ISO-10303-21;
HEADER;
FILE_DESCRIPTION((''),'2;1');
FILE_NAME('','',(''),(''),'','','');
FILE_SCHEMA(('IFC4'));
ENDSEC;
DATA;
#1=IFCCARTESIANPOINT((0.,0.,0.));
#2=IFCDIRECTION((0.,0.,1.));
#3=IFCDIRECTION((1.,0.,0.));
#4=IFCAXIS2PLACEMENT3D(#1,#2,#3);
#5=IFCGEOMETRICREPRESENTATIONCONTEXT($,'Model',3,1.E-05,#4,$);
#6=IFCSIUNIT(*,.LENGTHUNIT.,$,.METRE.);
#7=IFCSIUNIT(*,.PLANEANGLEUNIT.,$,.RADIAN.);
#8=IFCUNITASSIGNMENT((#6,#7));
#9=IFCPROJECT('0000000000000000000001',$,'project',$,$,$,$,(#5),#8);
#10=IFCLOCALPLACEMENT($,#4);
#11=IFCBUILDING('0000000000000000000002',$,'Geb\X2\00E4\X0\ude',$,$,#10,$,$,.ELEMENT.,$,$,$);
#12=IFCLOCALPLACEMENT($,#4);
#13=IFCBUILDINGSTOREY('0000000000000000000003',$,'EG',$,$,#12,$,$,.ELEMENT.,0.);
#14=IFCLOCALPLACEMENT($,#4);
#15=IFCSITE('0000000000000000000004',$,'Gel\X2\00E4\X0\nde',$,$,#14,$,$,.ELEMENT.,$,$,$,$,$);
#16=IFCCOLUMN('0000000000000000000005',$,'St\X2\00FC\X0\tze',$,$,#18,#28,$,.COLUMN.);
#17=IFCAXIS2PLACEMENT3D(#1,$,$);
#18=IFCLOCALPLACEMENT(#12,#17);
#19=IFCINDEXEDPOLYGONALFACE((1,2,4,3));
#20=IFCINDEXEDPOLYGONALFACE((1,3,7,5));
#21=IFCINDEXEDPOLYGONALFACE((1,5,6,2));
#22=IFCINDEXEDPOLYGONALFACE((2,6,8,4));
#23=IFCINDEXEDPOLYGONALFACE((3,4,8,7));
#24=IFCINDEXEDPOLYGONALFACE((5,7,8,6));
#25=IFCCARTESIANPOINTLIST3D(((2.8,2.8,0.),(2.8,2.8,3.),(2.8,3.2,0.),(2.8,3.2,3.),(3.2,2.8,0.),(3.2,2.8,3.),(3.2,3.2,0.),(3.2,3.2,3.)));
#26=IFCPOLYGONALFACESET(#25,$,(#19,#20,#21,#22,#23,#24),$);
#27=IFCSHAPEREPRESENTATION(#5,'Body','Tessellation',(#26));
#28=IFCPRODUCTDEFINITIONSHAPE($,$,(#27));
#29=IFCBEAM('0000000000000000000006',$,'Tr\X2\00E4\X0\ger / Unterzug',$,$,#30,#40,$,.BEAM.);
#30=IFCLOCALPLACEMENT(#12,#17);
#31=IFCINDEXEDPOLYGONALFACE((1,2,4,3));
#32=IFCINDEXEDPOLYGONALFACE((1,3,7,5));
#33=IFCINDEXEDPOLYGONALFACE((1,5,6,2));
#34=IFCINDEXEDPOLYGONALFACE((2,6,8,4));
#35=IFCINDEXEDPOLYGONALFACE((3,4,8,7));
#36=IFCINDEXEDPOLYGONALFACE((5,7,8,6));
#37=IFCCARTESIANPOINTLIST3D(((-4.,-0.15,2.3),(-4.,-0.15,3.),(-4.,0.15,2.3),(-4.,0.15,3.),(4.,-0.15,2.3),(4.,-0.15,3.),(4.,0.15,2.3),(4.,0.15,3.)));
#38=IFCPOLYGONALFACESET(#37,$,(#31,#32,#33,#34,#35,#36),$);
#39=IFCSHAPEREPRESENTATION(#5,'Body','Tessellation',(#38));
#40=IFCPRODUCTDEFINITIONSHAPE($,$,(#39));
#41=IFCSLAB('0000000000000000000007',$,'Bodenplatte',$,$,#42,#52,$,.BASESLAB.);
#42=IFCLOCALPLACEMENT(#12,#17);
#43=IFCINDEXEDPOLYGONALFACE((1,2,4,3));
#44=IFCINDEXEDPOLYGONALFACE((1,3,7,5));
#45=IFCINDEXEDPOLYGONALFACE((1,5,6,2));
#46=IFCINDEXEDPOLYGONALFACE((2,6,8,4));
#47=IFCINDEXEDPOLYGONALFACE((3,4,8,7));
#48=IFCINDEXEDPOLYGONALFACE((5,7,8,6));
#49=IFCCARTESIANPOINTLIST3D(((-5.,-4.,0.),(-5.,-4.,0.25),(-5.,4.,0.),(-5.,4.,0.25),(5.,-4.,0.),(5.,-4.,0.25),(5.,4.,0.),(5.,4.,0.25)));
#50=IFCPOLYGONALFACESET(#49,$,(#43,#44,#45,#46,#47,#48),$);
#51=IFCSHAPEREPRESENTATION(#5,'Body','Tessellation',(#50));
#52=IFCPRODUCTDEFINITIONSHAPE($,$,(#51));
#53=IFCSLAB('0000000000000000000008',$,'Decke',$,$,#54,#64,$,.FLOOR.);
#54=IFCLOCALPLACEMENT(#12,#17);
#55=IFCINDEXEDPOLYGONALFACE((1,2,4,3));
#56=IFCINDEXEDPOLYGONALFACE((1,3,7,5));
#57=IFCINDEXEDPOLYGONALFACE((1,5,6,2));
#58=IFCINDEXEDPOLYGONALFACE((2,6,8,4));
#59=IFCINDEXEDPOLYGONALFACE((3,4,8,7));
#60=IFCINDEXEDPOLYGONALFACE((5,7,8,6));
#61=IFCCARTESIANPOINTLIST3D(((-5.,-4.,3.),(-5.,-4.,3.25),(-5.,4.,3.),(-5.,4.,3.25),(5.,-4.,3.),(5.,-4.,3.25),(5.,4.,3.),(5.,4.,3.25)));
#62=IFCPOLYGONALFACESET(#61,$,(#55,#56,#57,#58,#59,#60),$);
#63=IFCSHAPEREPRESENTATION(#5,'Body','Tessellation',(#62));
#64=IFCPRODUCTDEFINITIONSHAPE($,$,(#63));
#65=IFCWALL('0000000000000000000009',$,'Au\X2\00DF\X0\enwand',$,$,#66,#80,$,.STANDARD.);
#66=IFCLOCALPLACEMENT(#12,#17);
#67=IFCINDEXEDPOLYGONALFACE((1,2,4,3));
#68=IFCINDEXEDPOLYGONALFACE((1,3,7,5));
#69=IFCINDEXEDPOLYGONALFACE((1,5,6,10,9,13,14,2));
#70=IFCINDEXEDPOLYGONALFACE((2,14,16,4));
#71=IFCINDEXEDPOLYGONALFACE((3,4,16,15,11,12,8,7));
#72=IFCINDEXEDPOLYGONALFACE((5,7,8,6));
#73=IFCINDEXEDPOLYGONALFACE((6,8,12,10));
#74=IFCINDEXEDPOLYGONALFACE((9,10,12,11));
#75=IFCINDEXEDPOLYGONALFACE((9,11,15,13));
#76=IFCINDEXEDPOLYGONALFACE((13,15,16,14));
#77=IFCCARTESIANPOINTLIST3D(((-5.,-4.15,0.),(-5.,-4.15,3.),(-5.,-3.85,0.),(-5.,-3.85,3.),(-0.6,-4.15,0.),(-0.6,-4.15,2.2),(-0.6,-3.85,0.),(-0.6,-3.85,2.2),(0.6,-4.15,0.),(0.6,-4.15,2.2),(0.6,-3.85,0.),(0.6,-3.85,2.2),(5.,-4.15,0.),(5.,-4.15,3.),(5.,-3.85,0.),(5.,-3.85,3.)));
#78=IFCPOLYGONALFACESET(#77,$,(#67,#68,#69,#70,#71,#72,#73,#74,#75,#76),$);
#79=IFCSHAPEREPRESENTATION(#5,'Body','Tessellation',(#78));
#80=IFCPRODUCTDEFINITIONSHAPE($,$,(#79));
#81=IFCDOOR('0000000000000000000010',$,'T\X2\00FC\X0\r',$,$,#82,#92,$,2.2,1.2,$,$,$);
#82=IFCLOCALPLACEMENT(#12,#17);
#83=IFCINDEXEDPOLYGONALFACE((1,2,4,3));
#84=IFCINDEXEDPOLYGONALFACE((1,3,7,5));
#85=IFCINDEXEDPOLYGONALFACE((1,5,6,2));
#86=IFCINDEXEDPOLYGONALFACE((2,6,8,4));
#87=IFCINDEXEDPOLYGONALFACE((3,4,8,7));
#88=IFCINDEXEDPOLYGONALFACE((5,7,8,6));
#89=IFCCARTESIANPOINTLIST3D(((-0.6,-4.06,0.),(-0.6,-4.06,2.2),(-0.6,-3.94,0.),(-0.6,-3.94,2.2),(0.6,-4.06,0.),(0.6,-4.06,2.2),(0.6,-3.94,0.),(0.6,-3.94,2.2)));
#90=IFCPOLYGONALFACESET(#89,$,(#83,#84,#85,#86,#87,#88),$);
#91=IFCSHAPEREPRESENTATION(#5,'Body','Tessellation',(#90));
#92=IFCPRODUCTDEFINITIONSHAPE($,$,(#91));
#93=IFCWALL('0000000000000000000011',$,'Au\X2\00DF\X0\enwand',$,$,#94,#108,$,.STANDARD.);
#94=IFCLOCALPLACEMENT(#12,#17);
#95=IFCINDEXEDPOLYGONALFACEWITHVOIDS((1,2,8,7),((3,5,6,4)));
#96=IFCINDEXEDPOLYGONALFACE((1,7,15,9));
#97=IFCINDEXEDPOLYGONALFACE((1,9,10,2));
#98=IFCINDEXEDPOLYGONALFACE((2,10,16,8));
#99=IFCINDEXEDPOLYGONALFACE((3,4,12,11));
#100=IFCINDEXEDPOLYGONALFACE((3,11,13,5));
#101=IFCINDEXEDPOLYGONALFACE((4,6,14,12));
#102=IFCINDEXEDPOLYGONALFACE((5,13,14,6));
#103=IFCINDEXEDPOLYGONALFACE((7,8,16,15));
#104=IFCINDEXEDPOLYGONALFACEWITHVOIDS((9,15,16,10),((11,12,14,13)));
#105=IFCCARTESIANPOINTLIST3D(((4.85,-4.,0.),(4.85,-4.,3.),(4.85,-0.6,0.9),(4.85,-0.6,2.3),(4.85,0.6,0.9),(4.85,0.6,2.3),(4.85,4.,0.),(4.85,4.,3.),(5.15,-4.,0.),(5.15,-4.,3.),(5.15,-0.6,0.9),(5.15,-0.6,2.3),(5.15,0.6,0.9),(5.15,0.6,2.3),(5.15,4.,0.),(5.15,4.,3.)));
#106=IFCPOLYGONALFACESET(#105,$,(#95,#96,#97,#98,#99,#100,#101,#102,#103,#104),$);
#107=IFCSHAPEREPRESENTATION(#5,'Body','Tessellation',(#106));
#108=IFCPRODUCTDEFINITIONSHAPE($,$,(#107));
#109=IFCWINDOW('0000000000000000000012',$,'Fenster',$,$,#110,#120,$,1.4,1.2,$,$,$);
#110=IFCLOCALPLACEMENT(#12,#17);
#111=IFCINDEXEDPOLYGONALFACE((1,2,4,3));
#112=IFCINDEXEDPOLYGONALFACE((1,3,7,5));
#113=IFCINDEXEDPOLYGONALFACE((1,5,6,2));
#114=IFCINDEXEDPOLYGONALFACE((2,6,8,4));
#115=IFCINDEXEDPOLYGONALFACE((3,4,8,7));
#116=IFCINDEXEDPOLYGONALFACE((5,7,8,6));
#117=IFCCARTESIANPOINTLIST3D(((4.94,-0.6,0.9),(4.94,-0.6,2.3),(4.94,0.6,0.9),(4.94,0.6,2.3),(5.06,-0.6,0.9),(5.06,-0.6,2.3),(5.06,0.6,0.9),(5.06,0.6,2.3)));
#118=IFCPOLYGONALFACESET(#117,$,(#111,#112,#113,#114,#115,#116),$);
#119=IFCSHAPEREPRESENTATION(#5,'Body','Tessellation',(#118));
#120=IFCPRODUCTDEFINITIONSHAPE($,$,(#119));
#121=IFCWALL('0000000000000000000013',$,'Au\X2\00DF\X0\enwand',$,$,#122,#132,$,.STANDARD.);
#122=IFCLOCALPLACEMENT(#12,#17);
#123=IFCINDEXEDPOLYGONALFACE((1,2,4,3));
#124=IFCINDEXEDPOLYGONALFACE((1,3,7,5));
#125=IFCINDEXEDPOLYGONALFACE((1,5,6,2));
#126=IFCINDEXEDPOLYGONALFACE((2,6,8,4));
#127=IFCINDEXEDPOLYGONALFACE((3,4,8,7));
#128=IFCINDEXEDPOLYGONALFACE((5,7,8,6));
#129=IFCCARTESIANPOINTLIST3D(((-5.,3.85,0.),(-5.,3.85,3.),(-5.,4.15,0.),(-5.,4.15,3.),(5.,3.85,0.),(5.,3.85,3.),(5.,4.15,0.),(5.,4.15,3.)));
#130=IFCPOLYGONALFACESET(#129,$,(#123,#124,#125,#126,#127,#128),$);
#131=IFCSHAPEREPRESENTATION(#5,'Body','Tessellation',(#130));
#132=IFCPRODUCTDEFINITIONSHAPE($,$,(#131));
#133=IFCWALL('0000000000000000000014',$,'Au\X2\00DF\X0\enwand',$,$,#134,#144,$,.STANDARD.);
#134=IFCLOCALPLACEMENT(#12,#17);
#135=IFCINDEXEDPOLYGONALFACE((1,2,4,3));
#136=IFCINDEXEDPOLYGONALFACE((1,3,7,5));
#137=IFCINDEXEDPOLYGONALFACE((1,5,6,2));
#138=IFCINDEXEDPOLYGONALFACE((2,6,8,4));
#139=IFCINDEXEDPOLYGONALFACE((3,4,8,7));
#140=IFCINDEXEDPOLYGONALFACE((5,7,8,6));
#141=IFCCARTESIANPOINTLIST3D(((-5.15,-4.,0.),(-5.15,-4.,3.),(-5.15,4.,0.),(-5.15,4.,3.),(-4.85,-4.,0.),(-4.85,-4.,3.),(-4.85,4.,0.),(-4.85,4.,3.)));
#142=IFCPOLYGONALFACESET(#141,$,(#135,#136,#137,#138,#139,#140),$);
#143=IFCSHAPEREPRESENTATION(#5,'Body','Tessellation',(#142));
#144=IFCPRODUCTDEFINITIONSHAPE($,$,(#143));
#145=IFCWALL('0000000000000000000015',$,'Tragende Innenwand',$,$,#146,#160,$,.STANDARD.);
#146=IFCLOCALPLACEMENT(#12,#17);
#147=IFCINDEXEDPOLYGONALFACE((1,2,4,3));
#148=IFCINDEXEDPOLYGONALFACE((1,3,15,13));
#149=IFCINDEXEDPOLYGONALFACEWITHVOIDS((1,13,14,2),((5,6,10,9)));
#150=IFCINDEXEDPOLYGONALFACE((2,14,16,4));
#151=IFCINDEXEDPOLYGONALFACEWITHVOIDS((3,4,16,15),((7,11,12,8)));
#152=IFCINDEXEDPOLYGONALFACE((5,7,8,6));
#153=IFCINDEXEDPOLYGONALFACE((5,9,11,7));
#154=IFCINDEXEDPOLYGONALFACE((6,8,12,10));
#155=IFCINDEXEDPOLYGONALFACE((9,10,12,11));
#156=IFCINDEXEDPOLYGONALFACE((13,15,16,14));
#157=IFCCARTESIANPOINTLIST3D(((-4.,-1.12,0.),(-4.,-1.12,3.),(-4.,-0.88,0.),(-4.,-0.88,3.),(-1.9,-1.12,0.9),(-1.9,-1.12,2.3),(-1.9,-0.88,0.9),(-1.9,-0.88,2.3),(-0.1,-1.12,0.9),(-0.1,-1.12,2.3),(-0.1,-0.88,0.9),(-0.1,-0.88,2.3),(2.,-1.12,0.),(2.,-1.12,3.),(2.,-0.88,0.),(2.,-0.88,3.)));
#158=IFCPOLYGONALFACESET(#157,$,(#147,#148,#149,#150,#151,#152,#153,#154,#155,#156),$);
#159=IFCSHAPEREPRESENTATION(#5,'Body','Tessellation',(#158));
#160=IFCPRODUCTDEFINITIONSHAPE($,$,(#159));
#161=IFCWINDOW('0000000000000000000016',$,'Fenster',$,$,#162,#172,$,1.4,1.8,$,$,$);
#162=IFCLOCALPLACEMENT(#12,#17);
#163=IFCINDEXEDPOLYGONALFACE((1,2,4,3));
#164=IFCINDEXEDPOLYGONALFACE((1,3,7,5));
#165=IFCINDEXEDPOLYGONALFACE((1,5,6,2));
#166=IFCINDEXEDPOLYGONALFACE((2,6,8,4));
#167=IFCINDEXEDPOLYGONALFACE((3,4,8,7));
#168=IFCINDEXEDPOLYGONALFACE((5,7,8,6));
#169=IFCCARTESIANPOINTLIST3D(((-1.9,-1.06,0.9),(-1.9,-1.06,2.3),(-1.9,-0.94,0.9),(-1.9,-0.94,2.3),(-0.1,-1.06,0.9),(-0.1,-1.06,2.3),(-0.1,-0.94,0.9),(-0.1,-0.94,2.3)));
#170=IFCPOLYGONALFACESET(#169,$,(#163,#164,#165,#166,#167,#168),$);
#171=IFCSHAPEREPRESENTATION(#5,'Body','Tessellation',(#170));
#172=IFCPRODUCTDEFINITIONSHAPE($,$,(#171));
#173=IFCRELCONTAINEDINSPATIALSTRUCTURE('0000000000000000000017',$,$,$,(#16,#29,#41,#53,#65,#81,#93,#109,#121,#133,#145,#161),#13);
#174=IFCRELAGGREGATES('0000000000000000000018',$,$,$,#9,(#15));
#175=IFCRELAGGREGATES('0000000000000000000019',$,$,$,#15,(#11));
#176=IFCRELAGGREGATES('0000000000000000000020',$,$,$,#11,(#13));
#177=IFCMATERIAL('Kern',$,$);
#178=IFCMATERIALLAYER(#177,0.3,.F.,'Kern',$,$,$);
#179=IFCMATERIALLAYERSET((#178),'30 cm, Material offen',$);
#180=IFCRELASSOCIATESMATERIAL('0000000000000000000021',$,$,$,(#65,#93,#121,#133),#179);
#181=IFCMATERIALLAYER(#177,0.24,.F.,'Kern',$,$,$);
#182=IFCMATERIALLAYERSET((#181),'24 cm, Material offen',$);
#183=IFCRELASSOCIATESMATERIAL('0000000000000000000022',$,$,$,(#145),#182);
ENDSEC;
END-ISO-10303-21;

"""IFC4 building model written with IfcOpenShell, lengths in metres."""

from ifc_helpers import new_model, si_unit, frame, origin_with_axes, origin_2d, place, context, project, spatial, polyline, rectangle, outline, extrude, material, layer, layer_set, element, fill, save


model = new_model("IFC4")

# Units and contexts
model_context = context("Model", 3, precision=1e-05, world=origin_with_axes())
ifc_project = project(units=[si_unit("LENGTHUNIT", "METRE"), si_unit("PLANEANGLEUNIT", "RADIAN")], contexts=[model_context])

# Site, building, storey
site_placement = place(None, origin_with_axes())
site = spatial("IfcSite", under=ifc_project, at=site_placement, Name="Gelände", CompositionType="ELEMENT")
building_placement = place(None, origin_with_axes())
building = spatial("IfcBuilding", under=site, at=building_placement, Name="Gebäude", CompositionType="ELEMENT")
storey_placement = place(None, origin_with_axes())
storey = spatial("IfcBuildingStorey", under=building, at=storey_placement, Name="EG", CompositionType="ELEMENT", Elevation=0.0)

# Column
column_placement = place(None, frame((3.0, 3.0, 0.0), z_axis=(0.0, 0.0, 1.0), x_axis=(1.0, 0.0, 0.0)))
element("IfcColumn", 1, at=column_placement, inside=storey, Name="Stütze", PredefinedType="COLUMN", context=model_context, shape_type="SweptSolid", body=[
    extrude(rectangle(XDim=0.4, YDim=0.4, at=origin_2d()), origin_with_axes(), (0.0, 0.0, 1.0), 3.0),
])

# Beam
beam_placement = place(None, frame((0.0, 0.0, 2.3), z_axis=(0.0, 0.0, 1.0), x_axis=(1.0, 0.0, 0.0)))
element("IfcBeam", 2, at=beam_placement, inside=storey, Name="Träger / Unterzug", PredefinedType="BEAM", context=model_context, shape_type="SweptSolid", body=[
    extrude(rectangle(XDim=8.0, YDim=0.3, at=origin_2d()), origin_with_axes(), (0.0, 0.0, 1.0), 0.7),
])

# Slabs
slab_1_placement = place(None, origin_with_axes())
element("IfcSlab", 3, at=slab_1_placement, inside=storey, Name="Bodenplatte", PredefinedType="BASESLAB", context=model_context, shape_type="SweptSolid", body=[
    extrude(outline(polyline([(-5.0, -4.0), (5.0, -4.0), (5.0, 4.0), (-5.0, 4.0), (-5.0, -4.0)])), origin_with_axes(), (0.0, 0.0, 1.0), 0.25),
])
slab_2_placement = place(None, frame((0.0, 0.0, 3.0), z_axis=(0.0, 0.0, 1.0), x_axis=(1.0, 0.0, 0.0)))
element("IfcSlab", 4, at=slab_2_placement, inside=storey, Name="Decke", PredefinedType="FLOOR", context=model_context, shape_type="SweptSolid", body=[
    extrude(outline(polyline([(-5.0, -4.0), (5.0, -4.0), (5.0, 4.0), (-5.0, 4.0), (-5.0, -4.0)])), origin_with_axes(), (0.0, 0.0, 1.0), 0.25),
])

# Wall, opening, door
ifc_material_1 = material(Name="Kern")
ifc_layer_1 = layer(ifc_material_1, 0.3, ventilated=False, Name="Kern")
ifc_layer_set_1 = layer_set([ifc_layer_1], Name="30 cm, Material offen")
wall_1_placement = place(None, frame((0.0, -4.0, 0.0), z_axis=(0.0, 0.0, 1.0), x_axis=(1.0, 0.0, 0.0)))
wall_1 = element("IfcWall", 5, at=wall_1_placement, inside=storey, material=ifc_layer_set_1, Name="Außenwand", PredefinedType="STANDARD", context=model_context, shape_type="SweptSolid", body=[
    extrude(rectangle(XDim=10.0, YDim=0.3, at=origin_2d()), origin_with_axes(), (0.0, 0.0, 1.0), 3.0),
])
opening_1_placement = place(wall_1_placement, origin_with_axes())
opening_1 = element("IfcOpeningElement", 6, at=opening_1_placement, cuts=wall_1, PredefinedType="OPENING", context=model_context, shape_type="SweptSolid", body=[
    extrude(rectangle(XDim=1.2, YDim=0.34, at=origin_2d()), origin_with_axes(), (0.0, 0.0, 1.0), 2.2),
])
door_1_placement = place(opening_1_placement, origin_with_axes())
door_1 = element("IfcDoor", 7, at=door_1_placement, inside=storey, Name="Tür", OverallHeight=2.2, OverallWidth=1.2, context=model_context, shape_type="SweptSolid", body=[
    extrude(rectangle(XDim=1.2, YDim=0.12, at=origin_2d()), origin_with_axes(), (0.0, 0.0, 1.0), 2.2),
])
fill(opening_1, door_1)

# Wall, opening, window
wall_2_placement = place(None, frame((5.0, 0.0, 0.0), z_axis=(0.0, 0.0, 1.0), x_axis=(0.0, 1.0, 0.0)))
wall_2 = element("IfcWall", 8, at=wall_2_placement, inside=storey, material=ifc_layer_set_1, Name="Außenwand", PredefinedType="STANDARD", context=model_context, shape_type="SweptSolid", body=[
    extrude(rectangle(XDim=8.0, YDim=0.3, at=origin_2d()), origin_with_axes(), (0.0, 0.0, 1.0), 3.0),
])
opening_2_placement = place(wall_2_placement, frame((0.0, 0.0, 0.9), z_axis=(0.0, 0.0, 1.0), x_axis=(1.0, 0.0, 0.0)))
opening_2 = element("IfcOpeningElement", 9, at=opening_2_placement, cuts=wall_2, PredefinedType="OPENING", context=model_context, shape_type="SweptSolid", body=[
    extrude(rectangle(XDim=1.2, YDim=0.34, at=origin_2d()), origin_with_axes(), (0.0, 0.0, 1.0), 1.4),
])
window_1_placement = place(opening_2_placement, origin_with_axes())
window_1 = element("IfcWindow", 10, at=window_1_placement, inside=storey, Name="Fenster", OverallHeight=1.4, OverallWidth=1.2, context=model_context, shape_type="SweptSolid", body=[
    extrude(rectangle(XDim=1.2, YDim=0.12, at=origin_2d()), origin_with_axes(), (0.0, 0.0, 1.0), 1.4),
])
fill(opening_2, window_1)

# Walls
wall_3_placement = place(None, frame((0.0, 4.0, 0.0), z_axis=(0.0, 0.0, 1.0), x_axis=(-1.0, 0.0, 0.0)))
element("IfcWall", 11, at=wall_3_placement, inside=storey, material=ifc_layer_set_1, Name="Außenwand", PredefinedType="STANDARD", context=model_context, shape_type="SweptSolid", body=[
    extrude(rectangle(XDim=10.0, YDim=0.3, at=origin_2d()), origin_with_axes(), (0.0, 0.0, 1.0), 3.0),
])
wall_4_placement = place(None, frame((-5.0, 0.0, 0.0), z_axis=(0.0, 0.0, 1.0), x_axis=(0.0, -1.0, 0.0)))
element("IfcWall", 12, at=wall_4_placement, inside=storey, material=ifc_layer_set_1, Name="Außenwand", PredefinedType="STANDARD", context=model_context, shape_type="SweptSolid", body=[
    extrude(rectangle(XDim=8.0, YDim=0.3, at=origin_2d()), origin_with_axes(), (0.0, 0.0, 1.0), 3.0),
])

# Wall, opening, window
ifc_layer_2 = layer(ifc_material_1, 0.24, ventilated=False, Name="Kern")
ifc_layer_set_2 = layer_set([ifc_layer_2], Name="24 cm, Material offen")
wall_5_placement = place(None, frame((-1.0, -1.0, 0.0), z_axis=(0.0, 0.0, 1.0), x_axis=(1.0, 0.0, 0.0)))
wall_5 = element("IfcWall", 13, at=wall_5_placement, inside=storey, material=ifc_layer_set_2, Name="Tragende Innenwand", PredefinedType="STANDARD", context=model_context, shape_type="SweptSolid", body=[
    extrude(rectangle(XDim=6.0, YDim=0.24, at=origin_2d()), origin_with_axes(), (0.0, 0.0, 1.0), 3.0),
])
opening_3_placement = place(wall_5_placement, frame((0.0, 0.0, 0.9), z_axis=(0.0, 0.0, 1.0), x_axis=(1.0, 0.0, 0.0)))
opening_3 = element("IfcOpeningElement", 14, at=opening_3_placement, cuts=wall_5, PredefinedType="OPENING", context=model_context, shape_type="SweptSolid", body=[
    extrude(rectangle(XDim=1.8, YDim=0.28, at=origin_2d()), origin_with_axes(), (0.0, 0.0, 1.0), 1.4),
])
window_2_placement = place(opening_3_placement, origin_with_axes())
window_2 = element("IfcWindow", 15, at=window_2_placement, inside=storey, Name="Fenster", OverallHeight=1.4, OverallWidth=1.8, context=model_context, shape_type="SweptSolid", body=[
    extrude(rectangle(XDim=1.8, YDim=0.12, at=origin_2d()), origin_with_axes(), (0.0, 0.0, 1.0), 1.4),
])
fill(opening_3, window_2)

save(model, "model.ifc")
